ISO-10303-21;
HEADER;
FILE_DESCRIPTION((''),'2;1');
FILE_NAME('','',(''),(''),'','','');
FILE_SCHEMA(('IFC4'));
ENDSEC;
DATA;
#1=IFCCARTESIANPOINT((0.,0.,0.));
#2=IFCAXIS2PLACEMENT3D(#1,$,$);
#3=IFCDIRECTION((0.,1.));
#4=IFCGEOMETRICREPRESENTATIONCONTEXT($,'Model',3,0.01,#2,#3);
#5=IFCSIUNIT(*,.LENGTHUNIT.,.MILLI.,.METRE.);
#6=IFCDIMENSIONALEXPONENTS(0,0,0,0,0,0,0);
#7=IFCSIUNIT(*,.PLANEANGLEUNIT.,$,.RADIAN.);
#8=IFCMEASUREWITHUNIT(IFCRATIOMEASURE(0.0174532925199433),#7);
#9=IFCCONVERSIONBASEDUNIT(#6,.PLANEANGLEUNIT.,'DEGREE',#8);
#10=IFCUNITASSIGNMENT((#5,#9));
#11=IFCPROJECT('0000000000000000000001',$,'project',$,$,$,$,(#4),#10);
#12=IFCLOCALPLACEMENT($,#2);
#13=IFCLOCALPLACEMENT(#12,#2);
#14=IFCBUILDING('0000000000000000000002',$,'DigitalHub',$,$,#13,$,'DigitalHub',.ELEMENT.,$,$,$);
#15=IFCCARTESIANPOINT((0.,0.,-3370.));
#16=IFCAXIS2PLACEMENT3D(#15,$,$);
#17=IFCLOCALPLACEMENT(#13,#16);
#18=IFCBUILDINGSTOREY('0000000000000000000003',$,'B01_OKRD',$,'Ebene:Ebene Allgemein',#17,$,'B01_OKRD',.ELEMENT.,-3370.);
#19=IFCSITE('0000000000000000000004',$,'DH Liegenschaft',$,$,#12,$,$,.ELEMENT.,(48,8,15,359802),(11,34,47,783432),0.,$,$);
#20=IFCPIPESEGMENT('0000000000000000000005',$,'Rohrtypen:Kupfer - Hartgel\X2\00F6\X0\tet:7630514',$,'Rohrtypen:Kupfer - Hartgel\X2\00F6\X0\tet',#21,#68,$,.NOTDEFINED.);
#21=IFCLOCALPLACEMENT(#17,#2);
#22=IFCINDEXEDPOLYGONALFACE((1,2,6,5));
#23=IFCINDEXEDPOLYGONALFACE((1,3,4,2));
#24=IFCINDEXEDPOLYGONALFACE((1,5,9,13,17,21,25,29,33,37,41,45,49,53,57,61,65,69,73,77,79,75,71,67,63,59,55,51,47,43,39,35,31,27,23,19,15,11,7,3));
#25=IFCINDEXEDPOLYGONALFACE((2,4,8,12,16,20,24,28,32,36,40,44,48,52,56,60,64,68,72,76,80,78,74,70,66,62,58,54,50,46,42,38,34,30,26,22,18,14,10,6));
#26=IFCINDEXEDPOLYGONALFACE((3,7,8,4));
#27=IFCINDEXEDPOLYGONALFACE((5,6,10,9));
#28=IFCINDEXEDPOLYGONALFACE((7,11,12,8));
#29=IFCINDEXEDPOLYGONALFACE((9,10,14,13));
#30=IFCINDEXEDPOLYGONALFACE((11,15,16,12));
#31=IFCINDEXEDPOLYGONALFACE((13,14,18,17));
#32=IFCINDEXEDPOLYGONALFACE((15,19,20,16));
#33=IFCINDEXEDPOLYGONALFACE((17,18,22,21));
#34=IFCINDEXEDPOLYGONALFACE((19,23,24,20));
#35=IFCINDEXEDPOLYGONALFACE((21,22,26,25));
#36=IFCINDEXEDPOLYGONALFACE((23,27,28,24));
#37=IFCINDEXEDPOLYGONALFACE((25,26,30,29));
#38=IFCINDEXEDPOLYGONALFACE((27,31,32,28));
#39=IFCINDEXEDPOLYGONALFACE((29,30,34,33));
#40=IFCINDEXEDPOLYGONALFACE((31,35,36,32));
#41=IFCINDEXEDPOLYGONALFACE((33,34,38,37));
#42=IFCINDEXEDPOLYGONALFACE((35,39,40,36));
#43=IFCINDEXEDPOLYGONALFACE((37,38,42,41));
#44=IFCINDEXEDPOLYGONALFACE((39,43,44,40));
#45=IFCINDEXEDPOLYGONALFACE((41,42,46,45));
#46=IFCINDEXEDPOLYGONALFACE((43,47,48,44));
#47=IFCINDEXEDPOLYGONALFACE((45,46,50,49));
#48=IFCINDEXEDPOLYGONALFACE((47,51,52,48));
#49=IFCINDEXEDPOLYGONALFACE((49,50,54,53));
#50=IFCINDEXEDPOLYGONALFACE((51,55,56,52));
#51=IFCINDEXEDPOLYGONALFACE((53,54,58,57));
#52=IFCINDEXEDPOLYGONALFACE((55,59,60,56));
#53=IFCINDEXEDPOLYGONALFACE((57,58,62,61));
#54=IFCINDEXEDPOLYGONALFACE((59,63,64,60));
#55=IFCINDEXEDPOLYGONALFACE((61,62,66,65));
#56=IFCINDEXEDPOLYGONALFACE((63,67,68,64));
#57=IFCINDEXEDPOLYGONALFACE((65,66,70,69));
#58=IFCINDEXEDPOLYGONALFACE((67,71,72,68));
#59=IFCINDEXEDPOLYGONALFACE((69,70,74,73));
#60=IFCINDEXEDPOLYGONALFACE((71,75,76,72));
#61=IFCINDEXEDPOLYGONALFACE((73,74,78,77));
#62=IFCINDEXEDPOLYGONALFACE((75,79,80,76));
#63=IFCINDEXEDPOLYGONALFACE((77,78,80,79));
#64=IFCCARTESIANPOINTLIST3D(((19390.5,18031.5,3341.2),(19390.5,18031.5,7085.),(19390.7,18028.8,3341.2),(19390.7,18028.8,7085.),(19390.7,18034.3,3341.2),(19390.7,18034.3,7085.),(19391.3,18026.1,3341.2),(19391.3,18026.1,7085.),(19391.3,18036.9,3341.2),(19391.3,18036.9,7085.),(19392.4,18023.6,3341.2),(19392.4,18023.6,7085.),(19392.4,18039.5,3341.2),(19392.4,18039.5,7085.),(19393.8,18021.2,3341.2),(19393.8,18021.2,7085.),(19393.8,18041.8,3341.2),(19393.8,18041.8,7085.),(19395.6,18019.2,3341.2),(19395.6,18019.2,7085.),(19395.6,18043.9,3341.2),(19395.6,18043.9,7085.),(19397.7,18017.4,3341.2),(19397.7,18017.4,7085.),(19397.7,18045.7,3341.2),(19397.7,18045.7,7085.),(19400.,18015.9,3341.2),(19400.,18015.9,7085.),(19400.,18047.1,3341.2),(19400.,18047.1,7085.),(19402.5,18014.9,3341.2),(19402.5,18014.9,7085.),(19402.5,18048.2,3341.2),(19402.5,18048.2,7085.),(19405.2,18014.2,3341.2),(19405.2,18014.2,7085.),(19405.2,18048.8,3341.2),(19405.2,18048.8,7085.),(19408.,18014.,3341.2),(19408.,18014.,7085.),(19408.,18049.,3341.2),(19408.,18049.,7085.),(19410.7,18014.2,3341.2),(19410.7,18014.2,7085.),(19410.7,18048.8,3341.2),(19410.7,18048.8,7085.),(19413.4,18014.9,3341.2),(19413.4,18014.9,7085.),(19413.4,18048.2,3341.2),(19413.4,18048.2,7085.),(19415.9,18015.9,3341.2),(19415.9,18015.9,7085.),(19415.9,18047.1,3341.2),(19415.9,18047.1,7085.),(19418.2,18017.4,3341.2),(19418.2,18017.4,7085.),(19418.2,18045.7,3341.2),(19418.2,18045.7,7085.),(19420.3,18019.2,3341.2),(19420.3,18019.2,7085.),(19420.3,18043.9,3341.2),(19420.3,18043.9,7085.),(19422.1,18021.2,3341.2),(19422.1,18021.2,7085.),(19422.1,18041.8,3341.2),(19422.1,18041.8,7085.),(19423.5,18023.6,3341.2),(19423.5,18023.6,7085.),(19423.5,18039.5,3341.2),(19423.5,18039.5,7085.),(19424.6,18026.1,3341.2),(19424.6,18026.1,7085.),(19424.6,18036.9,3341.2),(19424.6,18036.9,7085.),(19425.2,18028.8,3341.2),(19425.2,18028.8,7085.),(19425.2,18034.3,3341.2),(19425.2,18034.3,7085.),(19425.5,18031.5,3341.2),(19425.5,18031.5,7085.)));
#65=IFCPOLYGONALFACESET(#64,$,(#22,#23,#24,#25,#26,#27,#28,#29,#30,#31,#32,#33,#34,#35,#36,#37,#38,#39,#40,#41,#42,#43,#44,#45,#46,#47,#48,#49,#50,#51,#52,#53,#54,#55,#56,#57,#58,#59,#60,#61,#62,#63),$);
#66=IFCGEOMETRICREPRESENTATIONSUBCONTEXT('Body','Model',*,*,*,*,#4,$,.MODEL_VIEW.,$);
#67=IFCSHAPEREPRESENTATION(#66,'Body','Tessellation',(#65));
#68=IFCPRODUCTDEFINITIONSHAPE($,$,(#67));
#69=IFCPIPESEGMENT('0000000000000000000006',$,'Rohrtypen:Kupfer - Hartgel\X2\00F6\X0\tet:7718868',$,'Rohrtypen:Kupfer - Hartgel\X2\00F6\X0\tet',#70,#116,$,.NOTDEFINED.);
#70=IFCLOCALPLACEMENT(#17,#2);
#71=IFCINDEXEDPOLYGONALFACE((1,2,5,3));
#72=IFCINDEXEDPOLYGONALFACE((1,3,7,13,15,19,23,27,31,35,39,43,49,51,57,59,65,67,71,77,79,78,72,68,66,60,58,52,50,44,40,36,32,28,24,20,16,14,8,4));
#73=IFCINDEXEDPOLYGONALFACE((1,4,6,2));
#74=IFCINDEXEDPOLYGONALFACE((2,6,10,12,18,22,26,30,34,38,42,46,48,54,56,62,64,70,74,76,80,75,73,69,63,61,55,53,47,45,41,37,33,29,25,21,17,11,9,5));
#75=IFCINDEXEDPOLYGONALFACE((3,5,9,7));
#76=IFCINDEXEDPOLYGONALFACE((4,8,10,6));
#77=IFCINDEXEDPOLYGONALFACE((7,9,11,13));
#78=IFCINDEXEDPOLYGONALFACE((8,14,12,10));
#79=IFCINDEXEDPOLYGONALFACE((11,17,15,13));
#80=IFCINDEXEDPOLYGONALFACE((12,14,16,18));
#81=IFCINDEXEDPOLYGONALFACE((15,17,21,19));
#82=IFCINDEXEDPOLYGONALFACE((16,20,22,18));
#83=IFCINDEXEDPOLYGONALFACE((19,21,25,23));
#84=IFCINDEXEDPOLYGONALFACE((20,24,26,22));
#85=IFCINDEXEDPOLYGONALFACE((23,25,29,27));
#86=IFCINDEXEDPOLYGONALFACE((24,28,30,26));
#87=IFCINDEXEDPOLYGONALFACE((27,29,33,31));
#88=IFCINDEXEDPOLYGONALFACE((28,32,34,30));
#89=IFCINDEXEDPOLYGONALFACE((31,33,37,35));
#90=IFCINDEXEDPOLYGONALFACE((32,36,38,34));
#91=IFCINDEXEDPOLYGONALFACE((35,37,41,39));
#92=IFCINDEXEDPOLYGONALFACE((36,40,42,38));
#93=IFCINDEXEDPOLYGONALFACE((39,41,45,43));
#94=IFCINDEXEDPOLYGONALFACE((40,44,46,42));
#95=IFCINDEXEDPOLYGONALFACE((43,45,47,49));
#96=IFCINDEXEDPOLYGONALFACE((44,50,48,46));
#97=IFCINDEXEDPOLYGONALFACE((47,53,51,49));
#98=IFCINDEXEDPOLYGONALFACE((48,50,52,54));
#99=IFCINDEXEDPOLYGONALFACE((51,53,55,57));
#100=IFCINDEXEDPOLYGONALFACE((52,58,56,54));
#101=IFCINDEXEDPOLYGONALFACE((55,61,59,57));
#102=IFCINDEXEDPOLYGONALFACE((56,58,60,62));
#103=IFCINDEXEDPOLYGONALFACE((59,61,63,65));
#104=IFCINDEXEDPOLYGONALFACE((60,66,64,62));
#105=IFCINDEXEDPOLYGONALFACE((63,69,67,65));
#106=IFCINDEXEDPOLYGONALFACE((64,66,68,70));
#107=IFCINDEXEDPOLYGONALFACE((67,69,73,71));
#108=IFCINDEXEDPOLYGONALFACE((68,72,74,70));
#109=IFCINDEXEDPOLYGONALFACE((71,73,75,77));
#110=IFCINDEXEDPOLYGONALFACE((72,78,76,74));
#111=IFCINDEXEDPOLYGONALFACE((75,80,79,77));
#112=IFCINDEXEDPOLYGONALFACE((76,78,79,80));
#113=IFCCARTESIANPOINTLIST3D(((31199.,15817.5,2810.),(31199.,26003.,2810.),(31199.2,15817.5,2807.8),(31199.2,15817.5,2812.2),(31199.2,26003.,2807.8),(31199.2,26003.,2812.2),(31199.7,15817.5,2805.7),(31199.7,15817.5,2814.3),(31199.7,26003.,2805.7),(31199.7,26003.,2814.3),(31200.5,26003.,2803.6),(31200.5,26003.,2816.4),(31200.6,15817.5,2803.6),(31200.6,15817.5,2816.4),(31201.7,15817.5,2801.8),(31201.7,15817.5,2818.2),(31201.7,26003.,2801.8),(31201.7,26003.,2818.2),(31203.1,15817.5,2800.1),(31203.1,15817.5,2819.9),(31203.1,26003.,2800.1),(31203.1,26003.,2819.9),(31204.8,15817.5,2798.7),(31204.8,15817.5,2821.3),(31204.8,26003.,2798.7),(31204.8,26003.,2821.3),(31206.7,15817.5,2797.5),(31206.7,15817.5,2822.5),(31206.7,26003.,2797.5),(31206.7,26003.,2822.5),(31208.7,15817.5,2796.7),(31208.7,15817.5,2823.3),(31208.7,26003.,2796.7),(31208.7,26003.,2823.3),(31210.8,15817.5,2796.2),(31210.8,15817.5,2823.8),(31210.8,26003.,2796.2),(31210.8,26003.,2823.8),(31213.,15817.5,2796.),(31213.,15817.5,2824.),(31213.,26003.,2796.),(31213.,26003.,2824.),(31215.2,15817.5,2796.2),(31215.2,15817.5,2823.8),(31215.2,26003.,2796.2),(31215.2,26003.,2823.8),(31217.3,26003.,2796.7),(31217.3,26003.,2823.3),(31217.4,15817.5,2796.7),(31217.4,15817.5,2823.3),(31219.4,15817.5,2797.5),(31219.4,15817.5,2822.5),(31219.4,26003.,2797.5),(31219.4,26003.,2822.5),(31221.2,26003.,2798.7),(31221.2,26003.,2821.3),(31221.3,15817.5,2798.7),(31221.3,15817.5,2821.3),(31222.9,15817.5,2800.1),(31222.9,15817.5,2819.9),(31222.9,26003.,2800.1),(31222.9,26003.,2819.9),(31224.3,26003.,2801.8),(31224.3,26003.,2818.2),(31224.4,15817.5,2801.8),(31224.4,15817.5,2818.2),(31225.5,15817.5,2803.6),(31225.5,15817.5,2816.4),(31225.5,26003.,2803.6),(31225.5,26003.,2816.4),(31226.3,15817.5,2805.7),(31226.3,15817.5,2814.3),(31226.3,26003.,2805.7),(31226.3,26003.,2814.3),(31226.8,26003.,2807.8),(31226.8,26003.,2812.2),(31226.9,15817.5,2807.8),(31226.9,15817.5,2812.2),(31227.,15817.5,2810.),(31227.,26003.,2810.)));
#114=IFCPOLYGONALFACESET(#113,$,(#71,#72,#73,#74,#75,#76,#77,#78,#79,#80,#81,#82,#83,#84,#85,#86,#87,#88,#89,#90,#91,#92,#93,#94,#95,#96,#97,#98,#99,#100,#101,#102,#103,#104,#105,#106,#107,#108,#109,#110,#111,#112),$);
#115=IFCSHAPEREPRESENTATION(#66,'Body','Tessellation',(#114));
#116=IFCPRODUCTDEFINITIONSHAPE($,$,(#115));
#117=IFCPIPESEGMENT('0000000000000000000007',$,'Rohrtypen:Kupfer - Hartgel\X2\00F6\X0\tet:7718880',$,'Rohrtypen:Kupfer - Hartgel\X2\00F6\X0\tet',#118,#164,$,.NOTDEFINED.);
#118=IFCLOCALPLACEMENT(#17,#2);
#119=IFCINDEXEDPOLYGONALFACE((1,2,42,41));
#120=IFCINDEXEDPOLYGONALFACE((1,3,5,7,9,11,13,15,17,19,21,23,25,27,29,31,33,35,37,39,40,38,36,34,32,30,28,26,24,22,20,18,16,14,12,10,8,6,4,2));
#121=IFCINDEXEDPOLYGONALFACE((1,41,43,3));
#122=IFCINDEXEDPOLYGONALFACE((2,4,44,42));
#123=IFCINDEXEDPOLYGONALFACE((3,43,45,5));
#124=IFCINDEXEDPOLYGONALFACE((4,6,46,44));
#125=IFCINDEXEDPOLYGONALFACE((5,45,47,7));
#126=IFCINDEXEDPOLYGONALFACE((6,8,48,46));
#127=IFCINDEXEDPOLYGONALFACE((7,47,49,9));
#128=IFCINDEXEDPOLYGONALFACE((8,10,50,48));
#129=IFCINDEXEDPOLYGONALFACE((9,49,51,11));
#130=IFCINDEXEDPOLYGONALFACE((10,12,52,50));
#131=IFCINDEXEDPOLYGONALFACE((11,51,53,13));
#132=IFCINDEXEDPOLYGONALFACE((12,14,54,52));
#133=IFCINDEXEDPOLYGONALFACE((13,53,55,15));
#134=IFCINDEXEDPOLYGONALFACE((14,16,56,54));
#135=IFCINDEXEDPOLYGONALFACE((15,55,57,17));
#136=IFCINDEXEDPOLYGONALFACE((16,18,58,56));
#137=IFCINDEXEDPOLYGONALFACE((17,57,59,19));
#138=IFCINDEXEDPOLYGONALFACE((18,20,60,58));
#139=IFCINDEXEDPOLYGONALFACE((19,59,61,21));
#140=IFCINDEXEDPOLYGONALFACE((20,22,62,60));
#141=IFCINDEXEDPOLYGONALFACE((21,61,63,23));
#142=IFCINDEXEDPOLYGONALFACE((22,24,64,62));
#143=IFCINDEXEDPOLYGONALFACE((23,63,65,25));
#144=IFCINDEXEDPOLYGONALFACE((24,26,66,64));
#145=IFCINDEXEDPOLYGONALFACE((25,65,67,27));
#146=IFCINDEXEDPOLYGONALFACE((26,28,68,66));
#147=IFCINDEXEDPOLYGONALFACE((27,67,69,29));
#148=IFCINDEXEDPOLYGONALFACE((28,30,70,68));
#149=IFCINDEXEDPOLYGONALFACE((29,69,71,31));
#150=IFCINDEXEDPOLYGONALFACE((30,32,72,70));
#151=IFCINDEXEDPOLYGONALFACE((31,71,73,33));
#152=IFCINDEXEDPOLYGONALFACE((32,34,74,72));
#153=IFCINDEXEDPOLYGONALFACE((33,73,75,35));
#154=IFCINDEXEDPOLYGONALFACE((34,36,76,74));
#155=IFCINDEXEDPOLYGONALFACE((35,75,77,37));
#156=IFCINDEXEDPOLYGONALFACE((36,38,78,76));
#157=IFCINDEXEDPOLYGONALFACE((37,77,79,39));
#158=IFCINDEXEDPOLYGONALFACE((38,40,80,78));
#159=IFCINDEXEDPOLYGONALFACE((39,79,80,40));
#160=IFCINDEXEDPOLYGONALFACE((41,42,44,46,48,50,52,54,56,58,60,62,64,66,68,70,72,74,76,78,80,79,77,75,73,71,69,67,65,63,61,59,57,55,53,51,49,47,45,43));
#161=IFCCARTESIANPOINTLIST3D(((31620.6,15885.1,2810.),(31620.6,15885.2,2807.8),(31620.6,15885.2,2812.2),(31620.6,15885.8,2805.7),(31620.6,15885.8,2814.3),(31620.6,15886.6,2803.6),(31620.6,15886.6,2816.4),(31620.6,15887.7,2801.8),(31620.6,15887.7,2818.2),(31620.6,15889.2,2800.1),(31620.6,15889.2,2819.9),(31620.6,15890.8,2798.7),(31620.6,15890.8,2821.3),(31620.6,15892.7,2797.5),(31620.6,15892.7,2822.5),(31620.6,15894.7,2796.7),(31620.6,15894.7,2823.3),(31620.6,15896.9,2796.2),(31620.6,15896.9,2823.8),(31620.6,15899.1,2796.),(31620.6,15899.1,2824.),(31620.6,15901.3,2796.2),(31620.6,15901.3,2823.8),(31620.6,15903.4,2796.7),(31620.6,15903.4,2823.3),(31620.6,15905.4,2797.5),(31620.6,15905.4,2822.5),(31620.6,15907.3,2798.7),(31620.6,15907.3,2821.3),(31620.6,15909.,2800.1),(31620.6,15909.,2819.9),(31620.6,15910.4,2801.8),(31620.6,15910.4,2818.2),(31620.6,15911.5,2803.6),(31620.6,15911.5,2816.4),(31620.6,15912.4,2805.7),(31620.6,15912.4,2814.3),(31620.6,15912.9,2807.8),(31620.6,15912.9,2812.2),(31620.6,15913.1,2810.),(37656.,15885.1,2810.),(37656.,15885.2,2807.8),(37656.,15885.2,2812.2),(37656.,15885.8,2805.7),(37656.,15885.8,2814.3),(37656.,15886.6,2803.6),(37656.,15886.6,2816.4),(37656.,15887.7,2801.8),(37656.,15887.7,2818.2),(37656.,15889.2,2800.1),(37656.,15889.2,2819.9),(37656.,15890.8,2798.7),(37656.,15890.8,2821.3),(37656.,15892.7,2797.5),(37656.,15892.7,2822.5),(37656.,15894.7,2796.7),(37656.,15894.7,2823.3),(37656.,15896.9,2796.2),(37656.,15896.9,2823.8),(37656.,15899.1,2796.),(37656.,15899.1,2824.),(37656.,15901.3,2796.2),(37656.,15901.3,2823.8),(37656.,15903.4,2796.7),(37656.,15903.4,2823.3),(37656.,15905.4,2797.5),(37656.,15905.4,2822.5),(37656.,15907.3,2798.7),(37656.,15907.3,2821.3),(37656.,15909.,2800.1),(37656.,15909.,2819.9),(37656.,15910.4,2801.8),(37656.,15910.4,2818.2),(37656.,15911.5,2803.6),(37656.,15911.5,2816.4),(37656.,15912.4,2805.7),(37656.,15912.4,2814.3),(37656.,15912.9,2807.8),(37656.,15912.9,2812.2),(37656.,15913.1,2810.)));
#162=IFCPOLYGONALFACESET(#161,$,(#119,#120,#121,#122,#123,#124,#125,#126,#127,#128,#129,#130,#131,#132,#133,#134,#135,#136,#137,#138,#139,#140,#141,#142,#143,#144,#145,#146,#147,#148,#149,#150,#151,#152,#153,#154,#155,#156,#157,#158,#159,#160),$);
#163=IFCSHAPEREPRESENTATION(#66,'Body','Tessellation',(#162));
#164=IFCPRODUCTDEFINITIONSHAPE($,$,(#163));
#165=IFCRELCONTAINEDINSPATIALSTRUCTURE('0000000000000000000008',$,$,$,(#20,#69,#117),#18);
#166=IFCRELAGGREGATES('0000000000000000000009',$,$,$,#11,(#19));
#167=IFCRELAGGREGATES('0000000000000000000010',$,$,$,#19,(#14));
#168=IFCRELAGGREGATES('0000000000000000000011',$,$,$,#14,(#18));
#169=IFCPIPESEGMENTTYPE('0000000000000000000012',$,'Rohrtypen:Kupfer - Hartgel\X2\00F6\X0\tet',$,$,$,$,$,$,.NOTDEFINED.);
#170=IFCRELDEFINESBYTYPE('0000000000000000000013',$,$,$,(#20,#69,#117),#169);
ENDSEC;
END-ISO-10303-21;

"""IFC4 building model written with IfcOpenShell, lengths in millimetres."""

from ifc_helpers import new_model, entity, si_unit, converted_unit, direction, frame, origin, place, context, subcontext, project, spatial, indexed_curve, outline, extrude, type_object, element, save


model = new_model("IFC4")

# Units and contexts
model_context = context("Model", 3, precision=0.01, world=origin(), true_north=direction((0.0, 1.0)))
body_context = subcontext(model_context, "Body", "Model", "MODEL_VIEW")
ifc_project = project(units=[si_unit("LENGTHUNIT", "METRE", prefix="MILLI"), converted_unit("PLANEANGLEUNIT", "DEGREE", entity("IfcRatioMeasure", 0.0174532925199433), si_unit("PLANEANGLEUNIT", "RADIAN"), dimensions=[0, 0, 0, 0, 0, 0, 0])], contexts=[model_context])

# Site, building, storey
site_placement = place(None, origin())
site = spatial("IfcSite", under=ifc_project, at=site_placement, Name="DH Liegenschaft", CompositionType="ELEMENT", RefLatitude=(48, 8, 15, 359802), RefLongitude=(11, 34, 47, 783432), RefElevation=0.0)
building_placement = place(site_placement, origin())
building = spatial("IfcBuilding", under=site, at=building_placement, Name="DigitalHub", LongName="DigitalHub", CompositionType="ELEMENT")
storey_placement = place(building_placement, frame((0.0, 0.0, -3370.0)))
storey = spatial("IfcBuildingStorey", under=building, at=storey_placement, Name="B01_OKRD", ObjectType="Ebene:Ebene Allgemein", LongName="B01_OKRD", CompositionType="ELEMENT", Elevation=-3370.0)

# Pipe segments
pipe_segment_type = type_object("IfcPipeSegmentType", Name="Rohrtypen:Kupfer - Hartgelötet", PredefinedType="NOTDEFINED")
pipe_segment_1_placement = place(storey_placement, frame((19388.9, 18012.4, 3341.2)))
element("IfcPipeSegment", 1, at=pipe_segment_1_placement, inside=storey, type_object=pipe_segment_type, Name="Rohrtypen:Kupfer - Hartgelötet:7630514", ObjectType="Rohrtypen:Kupfer - Hartgelötet", PredefinedType="NOTDEFINED", context=body_context, shape_type="SweptSolid", body=[
    extrude(outline(indexed_curve([(17.5, 0.0), (17.3, 2.7), (16.6, 5.4), (15.6, 7.9), (14.2, 10.3), (12.4, 12.4), (10.3, 14.2), (7.9, 15.6), (5.4, 16.6), (2.7, 17.3), (0.0, 17.5), (-2.7, 17.3), (-5.4, 16.6), (-7.9, 15.6), (-10.3, 14.2), (-12.4, 12.4), (-14.2, 10.3), (-15.6, 7.9), (-16.6, 5.4), (-17.3, 2.7), (-17.5, 0.0), (-17.3, -2.7), (-16.6, -5.4), (-15.6, -7.9), (-14.2, -10.3), (-12.4, -12.4), (-10.3, -14.2), (-7.9, -15.6), (-5.4, -16.6), (-2.7, -17.3), (0.0, -17.5), (2.7, -17.3), (5.4, -16.6), (7.9, -15.6), (10.3, -14.2), (12.4, -12.4), (14.2, -10.3), (15.6, -7.9), (16.6, -5.4), (17.3, -2.7), (17.5, 0.0)], self_intersect=False)), frame((19.1, 19.1, 0.0)), (0.0, 0.0, 1.0), 3743.8),
])
pipe_segment_2_placement = place(storey_placement, frame((31197.4, 15817.5, 2794.4)))
element("IfcPipeSegment", 2, at=pipe_segment_2_placement, inside=storey, type_object=pipe_segment_type, Name="Rohrtypen:Kupfer - Hartgelötet:7718868", ObjectType="Rohrtypen:Kupfer - Hartgelötet", PredefinedType="NOTDEFINED", context=body_context, shape_type="SweptSolid", body=[
    extrude(outline(indexed_curve([(14.0, 0.0), (13.8, 2.2), (13.3, 4.3), (12.5, 6.4), (11.3, 8.2), (9.9, 9.9), (8.2, 11.3), (6.4, 12.5), (4.3, 13.3), (2.2, 13.8), (0.0, 14.0), (-2.2, 13.8), (-4.3, 13.3), (-6.4, 12.5), (-8.2, 11.3), (-9.9, 9.9), (-11.3, 8.2), (-12.5, 6.4), (-13.3, 4.3), (-13.8, 2.2), (-14.0, 0.0), (-13.8, -2.2), (-13.3, -4.3), (-12.5, -6.4), (-11.3, -8.2), (-9.9, -9.9), (-8.2, -11.3), (-6.4, -12.5), (-4.3, -13.3), (-2.2, -13.8), (0.0, -14.0), (2.2, -13.8), (4.3, -13.3), (6.4, -12.5), (8.2, -11.3), (9.9, -9.9), (11.3, -8.2), (12.5, -6.4), (13.3, -4.3), (13.8, -2.2), (14.0, 0.0)], self_intersect=False)), frame((15.6, 0.0, 15.6), z_axis=(-0.000002, 1.0, 0.0), x_axis=(-1.0, -0.000002, 0.0)), (0.0, 0.0, 1.0), 10185.5),
])
pipe_segment_3_placement = place(storey_placement, frame((31620.6, 15883.5, 2794.4)))
element("IfcPipeSegment", 3, at=pipe_segment_3_placement, inside=storey, type_object=pipe_segment_type, Name="Rohrtypen:Kupfer - Hartgelötet:7718880", ObjectType="Rohrtypen:Kupfer - Hartgelötet", PredefinedType="NOTDEFINED", context=body_context, shape_type="SweptSolid", body=[
    extrude(outline(indexed_curve([(14.0, 0.0), (13.8, 2.2), (13.3, 4.3), (12.5, 6.4), (11.3, 8.2), (9.9, 9.9), (8.2, 11.3), (6.4, 12.5), (4.3, 13.3), (2.2, 13.8), (0.0, 14.0), (-2.2, 13.8), (-4.3, 13.3), (-6.4, 12.5), (-8.2, 11.3), (-9.9, 9.9), (-11.3, 8.2), (-12.5, 6.4), (-13.3, 4.3), (-13.8, 2.2), (-14.0, 0.0), (-13.8, -2.2), (-13.3, -4.3), (-12.5, -6.4), (-11.3, -8.2), (-9.9, -9.9), (-8.2, -11.3), (-6.4, -12.5), (-4.3, -13.3), (-2.2, -13.8), (0.0, -14.0), (2.2, -13.8), (4.3, -13.3), (6.4, -12.5), (8.2, -11.3), (9.9, -9.9), (11.3, -8.2), (12.5, -6.4), (13.3, -4.3), (13.8, -2.2), (14.0, 0.0)], self_intersect=False)), frame((0.0, 15.6, 15.6), z_axis=(1.0, 0.0, 0.0), x_axis=(0.0, -1.0, 0.0)), (0.0, 0.0, 1.0), 6035.3),
])

save(model, "model.ifc")
